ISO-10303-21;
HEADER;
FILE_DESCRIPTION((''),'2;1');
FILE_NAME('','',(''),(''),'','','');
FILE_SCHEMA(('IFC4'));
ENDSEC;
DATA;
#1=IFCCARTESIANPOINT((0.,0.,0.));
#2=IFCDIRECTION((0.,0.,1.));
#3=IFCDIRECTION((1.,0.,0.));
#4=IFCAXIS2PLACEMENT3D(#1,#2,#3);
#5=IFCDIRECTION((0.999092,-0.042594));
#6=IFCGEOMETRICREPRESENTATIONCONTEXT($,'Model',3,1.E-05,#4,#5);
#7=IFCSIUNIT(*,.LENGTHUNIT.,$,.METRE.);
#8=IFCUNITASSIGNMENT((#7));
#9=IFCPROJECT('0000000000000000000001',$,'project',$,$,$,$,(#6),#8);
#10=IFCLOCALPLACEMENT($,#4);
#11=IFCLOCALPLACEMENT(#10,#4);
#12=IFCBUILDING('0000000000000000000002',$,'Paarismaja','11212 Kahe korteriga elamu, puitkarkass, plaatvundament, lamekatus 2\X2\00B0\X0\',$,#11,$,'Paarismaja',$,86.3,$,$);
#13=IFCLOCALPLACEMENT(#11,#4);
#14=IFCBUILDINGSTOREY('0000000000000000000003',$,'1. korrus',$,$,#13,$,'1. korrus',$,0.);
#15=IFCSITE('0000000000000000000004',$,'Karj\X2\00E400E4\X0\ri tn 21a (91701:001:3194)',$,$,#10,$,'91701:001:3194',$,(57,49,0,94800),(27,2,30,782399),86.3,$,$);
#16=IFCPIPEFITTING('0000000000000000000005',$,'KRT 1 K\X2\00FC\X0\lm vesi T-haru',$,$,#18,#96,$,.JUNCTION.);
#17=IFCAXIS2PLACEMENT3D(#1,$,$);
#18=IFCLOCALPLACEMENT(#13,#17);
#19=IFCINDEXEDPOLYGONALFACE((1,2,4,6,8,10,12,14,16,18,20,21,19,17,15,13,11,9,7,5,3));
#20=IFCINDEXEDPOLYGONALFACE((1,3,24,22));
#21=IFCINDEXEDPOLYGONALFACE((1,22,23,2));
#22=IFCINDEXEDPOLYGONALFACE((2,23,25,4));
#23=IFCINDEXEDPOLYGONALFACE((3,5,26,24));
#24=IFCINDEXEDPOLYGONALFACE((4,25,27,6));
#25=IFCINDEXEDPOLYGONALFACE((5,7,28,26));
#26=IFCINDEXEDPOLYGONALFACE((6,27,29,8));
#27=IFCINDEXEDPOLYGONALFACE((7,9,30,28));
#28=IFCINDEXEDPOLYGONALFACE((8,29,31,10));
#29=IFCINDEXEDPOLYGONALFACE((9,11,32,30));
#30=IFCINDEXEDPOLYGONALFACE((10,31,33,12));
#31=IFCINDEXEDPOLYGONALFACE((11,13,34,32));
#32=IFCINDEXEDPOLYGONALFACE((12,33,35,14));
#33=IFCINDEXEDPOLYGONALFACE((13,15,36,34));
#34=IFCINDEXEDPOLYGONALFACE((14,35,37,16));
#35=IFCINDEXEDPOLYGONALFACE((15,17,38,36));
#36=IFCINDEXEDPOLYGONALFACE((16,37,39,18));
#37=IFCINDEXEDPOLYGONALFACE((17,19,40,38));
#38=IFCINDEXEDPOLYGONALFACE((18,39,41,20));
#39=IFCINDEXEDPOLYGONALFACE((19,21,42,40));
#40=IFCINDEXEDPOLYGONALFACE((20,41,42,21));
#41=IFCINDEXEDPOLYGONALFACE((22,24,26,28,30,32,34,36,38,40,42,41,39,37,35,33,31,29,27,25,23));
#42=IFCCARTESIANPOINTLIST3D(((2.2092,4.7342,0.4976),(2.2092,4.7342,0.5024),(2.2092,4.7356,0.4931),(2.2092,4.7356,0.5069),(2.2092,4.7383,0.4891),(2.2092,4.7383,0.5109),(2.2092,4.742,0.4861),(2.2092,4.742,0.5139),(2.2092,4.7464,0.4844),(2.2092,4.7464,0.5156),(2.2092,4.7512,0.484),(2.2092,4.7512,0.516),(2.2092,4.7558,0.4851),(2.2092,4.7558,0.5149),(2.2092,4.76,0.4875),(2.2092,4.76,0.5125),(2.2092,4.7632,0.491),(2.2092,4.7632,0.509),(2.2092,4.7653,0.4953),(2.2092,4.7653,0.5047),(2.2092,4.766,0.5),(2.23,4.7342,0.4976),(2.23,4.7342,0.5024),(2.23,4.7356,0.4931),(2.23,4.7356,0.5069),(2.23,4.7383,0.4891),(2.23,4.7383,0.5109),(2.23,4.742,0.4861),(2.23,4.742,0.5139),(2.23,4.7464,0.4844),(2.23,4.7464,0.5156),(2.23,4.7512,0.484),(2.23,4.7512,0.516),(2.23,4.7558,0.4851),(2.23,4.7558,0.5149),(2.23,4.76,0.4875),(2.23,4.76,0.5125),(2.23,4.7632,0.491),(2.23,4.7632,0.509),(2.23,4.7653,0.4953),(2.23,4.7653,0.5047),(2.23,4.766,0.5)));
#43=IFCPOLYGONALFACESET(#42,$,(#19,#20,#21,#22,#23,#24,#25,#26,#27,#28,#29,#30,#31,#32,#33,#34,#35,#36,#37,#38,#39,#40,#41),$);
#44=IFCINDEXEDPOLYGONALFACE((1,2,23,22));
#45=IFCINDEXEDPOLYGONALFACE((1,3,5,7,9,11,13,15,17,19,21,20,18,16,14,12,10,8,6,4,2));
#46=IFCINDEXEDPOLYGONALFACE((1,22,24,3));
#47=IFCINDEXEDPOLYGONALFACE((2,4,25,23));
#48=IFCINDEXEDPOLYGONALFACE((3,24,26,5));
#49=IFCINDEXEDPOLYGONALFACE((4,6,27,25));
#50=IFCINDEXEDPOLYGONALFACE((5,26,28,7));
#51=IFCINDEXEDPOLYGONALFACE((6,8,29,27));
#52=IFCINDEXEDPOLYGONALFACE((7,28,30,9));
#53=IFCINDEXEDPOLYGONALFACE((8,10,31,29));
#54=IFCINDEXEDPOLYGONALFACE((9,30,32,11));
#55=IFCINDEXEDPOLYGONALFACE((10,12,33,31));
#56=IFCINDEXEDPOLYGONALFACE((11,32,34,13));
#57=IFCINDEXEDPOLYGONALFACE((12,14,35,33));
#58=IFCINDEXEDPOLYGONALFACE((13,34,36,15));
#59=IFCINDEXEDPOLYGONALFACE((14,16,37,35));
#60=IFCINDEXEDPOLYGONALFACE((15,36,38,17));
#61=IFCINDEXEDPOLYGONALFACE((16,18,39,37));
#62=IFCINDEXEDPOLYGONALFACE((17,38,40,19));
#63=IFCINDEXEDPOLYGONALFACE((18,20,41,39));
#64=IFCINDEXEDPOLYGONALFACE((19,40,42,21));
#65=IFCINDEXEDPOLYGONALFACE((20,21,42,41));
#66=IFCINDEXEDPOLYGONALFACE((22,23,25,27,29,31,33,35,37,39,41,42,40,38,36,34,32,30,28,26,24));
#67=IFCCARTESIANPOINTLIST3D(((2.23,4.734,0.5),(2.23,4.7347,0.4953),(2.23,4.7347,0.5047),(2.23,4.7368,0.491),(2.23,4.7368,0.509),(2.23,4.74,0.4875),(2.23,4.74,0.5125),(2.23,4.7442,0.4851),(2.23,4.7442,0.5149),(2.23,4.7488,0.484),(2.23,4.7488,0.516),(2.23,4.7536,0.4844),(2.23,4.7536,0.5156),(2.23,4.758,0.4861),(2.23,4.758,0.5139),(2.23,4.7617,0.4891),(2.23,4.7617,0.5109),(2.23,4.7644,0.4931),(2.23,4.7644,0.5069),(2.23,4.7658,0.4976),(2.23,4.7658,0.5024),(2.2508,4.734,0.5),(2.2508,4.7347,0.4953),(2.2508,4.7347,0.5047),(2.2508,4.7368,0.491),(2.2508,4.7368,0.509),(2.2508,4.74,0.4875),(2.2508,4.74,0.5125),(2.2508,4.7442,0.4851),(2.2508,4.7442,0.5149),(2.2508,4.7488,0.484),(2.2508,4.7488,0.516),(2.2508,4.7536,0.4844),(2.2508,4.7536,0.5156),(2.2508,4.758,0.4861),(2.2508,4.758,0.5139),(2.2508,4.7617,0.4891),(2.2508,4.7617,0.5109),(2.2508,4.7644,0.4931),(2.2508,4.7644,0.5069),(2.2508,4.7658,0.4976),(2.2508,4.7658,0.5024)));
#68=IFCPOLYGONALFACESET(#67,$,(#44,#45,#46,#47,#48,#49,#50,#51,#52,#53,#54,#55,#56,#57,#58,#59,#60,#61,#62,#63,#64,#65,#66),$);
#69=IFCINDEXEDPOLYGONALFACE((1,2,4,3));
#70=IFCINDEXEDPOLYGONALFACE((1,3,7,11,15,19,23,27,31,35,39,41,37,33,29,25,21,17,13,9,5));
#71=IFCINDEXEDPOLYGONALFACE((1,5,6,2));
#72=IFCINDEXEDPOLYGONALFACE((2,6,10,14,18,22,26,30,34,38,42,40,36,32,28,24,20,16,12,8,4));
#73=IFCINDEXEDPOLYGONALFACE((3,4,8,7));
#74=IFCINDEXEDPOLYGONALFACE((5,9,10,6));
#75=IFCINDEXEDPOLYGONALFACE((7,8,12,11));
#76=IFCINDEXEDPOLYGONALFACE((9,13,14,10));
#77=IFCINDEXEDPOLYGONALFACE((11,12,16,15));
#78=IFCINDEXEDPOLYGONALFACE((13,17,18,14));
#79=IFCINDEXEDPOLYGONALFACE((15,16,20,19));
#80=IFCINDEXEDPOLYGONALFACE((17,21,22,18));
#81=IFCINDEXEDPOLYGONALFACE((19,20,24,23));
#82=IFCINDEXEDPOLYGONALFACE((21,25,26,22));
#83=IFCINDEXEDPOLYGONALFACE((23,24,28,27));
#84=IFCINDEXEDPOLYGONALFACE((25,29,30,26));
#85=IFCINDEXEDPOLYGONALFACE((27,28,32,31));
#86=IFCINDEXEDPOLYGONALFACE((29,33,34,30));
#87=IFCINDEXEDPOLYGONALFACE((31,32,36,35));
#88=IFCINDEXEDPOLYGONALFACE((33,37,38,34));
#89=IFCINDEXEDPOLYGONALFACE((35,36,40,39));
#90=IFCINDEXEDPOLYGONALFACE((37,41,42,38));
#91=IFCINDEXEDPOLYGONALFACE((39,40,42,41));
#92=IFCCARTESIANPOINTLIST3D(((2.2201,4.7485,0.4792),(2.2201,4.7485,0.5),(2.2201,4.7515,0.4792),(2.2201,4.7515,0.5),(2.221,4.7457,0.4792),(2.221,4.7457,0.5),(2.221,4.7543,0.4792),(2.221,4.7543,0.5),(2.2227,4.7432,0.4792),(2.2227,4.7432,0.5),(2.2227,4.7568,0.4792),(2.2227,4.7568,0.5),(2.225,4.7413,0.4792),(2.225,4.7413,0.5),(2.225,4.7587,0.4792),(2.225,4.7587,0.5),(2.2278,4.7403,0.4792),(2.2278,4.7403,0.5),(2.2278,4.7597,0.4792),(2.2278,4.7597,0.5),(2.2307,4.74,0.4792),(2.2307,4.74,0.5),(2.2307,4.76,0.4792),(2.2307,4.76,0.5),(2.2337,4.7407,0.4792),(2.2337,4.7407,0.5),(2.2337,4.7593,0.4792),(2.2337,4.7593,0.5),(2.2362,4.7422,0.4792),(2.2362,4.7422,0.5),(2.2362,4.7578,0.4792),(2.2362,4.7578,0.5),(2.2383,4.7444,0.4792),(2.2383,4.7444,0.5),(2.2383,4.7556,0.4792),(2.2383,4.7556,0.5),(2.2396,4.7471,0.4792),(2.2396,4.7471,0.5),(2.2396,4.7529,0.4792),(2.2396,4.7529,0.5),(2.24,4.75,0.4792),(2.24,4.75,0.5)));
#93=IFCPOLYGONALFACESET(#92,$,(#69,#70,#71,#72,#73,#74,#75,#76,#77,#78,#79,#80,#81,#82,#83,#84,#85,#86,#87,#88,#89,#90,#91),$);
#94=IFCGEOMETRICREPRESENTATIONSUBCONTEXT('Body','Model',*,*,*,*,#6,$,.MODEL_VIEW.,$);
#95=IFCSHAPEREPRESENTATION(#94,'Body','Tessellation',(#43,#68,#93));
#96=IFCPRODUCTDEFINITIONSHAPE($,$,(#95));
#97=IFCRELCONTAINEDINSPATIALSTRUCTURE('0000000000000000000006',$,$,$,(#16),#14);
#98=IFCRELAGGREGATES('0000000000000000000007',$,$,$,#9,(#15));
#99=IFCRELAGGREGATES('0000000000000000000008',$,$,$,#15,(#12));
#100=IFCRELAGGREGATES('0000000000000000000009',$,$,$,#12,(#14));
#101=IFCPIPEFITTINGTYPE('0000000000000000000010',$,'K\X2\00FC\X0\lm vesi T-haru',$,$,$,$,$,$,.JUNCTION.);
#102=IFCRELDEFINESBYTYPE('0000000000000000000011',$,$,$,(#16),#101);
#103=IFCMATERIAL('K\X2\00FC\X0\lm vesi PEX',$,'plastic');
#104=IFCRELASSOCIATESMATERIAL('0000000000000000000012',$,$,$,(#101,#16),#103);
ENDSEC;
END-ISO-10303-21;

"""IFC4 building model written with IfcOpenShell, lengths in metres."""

from ifc_helpers import new_model, si_unit, direction, frame, origin_with_axes, place, context, subcontext, project, spatial, circle, extrude, material, type_object, element, save


model = new_model("IFC4")

# Units and contexts
model_context = context("Model", 3, precision=1e-05, world=origin_with_axes(), true_north=direction((0.999092, -0.042594)))
body_context = subcontext(model_context, "Body", "Model", "MODEL_VIEW")
ifc_project = project(units=[si_unit("LENGTHUNIT", "METRE")], contexts=[model_context])

# Site, building, storey
site_placement = place(None, origin_with_axes())
site = spatial("IfcSite", under=ifc_project, at=site_placement, Name="Karjääri tn 21a (91701:001:3194)", LongName="91701:001:3194", RefLatitude=(57, 49, 0, 94800), RefLongitude=(27, 2, 30, 782399), RefElevation=86.3)
building_placement = place(site_placement, origin_with_axes())
building = spatial("IfcBuilding", under=site, at=building_placement, Name="Paarismaja", Description="11212 Kahe korteriga elamu, puitkarkass, plaatvundament, lamekatus 2°", LongName="Paarismaja", ElevationOfRefHeight=86.3)
storey_placement = place(building_placement, origin_with_axes())
storey = spatial("IfcBuildingStorey", under=building, at=storey_placement, Name="1. korrus", LongName="1. korrus", Elevation=0.0)

# Pipe fitting
ifc_material_1 = material(Name="Külm vesi PEX", Category="plastic")
pipe_fitting_type_1 = type_object("IfcPipeFittingType", Name="Külm vesi T-haru", PredefinedType="JUNCTION", material=ifc_material_1)
for number, where, z_axis, x_axis, name in (
    (1, (2.23, 4.75, 0.5), (0.0, 0.0, 1.0), (1.0, 0.0, 0.0), "KRT 1 Külm vesi T-haru"),
):
    element("IfcPipeFitting", number, at=place(storey_placement, frame(where, z_axis=z_axis, x_axis=x_axis)), inside=storey, type_object=pipe_fitting_type_1, material=ifc_material_1, Name=name, PredefinedType="JUNCTION", context=body_context, shape_type="SweptSolid", body=[
        extrude(circle(Radius=0.016), frame((0.0, 0.0, 0.0), z_axis=(-1.0, 0.0, 0.0), x_axis=(0.0, 1.0, 0.0)), (0.0, 0.0, 1.0), 0.0208),
        extrude(circle(Radius=0.016), frame((0.0, 0.0, 0.0), z_axis=(1.0, 0.0, 0.0), x_axis=(0.0, -1.0, 0.0)), (0.0, 0.0, 1.0), 0.0208),
        extrude(circle(Radius=0.01), frame((0.0, 0.0, 0.0), z_axis=(0.0, 0.0, -1.0), x_axis=(1.0, 0.0, 0.0)), (0.0, 0.0, 1.0), 0.0208),
    ])

save(model, "model.ifc")
